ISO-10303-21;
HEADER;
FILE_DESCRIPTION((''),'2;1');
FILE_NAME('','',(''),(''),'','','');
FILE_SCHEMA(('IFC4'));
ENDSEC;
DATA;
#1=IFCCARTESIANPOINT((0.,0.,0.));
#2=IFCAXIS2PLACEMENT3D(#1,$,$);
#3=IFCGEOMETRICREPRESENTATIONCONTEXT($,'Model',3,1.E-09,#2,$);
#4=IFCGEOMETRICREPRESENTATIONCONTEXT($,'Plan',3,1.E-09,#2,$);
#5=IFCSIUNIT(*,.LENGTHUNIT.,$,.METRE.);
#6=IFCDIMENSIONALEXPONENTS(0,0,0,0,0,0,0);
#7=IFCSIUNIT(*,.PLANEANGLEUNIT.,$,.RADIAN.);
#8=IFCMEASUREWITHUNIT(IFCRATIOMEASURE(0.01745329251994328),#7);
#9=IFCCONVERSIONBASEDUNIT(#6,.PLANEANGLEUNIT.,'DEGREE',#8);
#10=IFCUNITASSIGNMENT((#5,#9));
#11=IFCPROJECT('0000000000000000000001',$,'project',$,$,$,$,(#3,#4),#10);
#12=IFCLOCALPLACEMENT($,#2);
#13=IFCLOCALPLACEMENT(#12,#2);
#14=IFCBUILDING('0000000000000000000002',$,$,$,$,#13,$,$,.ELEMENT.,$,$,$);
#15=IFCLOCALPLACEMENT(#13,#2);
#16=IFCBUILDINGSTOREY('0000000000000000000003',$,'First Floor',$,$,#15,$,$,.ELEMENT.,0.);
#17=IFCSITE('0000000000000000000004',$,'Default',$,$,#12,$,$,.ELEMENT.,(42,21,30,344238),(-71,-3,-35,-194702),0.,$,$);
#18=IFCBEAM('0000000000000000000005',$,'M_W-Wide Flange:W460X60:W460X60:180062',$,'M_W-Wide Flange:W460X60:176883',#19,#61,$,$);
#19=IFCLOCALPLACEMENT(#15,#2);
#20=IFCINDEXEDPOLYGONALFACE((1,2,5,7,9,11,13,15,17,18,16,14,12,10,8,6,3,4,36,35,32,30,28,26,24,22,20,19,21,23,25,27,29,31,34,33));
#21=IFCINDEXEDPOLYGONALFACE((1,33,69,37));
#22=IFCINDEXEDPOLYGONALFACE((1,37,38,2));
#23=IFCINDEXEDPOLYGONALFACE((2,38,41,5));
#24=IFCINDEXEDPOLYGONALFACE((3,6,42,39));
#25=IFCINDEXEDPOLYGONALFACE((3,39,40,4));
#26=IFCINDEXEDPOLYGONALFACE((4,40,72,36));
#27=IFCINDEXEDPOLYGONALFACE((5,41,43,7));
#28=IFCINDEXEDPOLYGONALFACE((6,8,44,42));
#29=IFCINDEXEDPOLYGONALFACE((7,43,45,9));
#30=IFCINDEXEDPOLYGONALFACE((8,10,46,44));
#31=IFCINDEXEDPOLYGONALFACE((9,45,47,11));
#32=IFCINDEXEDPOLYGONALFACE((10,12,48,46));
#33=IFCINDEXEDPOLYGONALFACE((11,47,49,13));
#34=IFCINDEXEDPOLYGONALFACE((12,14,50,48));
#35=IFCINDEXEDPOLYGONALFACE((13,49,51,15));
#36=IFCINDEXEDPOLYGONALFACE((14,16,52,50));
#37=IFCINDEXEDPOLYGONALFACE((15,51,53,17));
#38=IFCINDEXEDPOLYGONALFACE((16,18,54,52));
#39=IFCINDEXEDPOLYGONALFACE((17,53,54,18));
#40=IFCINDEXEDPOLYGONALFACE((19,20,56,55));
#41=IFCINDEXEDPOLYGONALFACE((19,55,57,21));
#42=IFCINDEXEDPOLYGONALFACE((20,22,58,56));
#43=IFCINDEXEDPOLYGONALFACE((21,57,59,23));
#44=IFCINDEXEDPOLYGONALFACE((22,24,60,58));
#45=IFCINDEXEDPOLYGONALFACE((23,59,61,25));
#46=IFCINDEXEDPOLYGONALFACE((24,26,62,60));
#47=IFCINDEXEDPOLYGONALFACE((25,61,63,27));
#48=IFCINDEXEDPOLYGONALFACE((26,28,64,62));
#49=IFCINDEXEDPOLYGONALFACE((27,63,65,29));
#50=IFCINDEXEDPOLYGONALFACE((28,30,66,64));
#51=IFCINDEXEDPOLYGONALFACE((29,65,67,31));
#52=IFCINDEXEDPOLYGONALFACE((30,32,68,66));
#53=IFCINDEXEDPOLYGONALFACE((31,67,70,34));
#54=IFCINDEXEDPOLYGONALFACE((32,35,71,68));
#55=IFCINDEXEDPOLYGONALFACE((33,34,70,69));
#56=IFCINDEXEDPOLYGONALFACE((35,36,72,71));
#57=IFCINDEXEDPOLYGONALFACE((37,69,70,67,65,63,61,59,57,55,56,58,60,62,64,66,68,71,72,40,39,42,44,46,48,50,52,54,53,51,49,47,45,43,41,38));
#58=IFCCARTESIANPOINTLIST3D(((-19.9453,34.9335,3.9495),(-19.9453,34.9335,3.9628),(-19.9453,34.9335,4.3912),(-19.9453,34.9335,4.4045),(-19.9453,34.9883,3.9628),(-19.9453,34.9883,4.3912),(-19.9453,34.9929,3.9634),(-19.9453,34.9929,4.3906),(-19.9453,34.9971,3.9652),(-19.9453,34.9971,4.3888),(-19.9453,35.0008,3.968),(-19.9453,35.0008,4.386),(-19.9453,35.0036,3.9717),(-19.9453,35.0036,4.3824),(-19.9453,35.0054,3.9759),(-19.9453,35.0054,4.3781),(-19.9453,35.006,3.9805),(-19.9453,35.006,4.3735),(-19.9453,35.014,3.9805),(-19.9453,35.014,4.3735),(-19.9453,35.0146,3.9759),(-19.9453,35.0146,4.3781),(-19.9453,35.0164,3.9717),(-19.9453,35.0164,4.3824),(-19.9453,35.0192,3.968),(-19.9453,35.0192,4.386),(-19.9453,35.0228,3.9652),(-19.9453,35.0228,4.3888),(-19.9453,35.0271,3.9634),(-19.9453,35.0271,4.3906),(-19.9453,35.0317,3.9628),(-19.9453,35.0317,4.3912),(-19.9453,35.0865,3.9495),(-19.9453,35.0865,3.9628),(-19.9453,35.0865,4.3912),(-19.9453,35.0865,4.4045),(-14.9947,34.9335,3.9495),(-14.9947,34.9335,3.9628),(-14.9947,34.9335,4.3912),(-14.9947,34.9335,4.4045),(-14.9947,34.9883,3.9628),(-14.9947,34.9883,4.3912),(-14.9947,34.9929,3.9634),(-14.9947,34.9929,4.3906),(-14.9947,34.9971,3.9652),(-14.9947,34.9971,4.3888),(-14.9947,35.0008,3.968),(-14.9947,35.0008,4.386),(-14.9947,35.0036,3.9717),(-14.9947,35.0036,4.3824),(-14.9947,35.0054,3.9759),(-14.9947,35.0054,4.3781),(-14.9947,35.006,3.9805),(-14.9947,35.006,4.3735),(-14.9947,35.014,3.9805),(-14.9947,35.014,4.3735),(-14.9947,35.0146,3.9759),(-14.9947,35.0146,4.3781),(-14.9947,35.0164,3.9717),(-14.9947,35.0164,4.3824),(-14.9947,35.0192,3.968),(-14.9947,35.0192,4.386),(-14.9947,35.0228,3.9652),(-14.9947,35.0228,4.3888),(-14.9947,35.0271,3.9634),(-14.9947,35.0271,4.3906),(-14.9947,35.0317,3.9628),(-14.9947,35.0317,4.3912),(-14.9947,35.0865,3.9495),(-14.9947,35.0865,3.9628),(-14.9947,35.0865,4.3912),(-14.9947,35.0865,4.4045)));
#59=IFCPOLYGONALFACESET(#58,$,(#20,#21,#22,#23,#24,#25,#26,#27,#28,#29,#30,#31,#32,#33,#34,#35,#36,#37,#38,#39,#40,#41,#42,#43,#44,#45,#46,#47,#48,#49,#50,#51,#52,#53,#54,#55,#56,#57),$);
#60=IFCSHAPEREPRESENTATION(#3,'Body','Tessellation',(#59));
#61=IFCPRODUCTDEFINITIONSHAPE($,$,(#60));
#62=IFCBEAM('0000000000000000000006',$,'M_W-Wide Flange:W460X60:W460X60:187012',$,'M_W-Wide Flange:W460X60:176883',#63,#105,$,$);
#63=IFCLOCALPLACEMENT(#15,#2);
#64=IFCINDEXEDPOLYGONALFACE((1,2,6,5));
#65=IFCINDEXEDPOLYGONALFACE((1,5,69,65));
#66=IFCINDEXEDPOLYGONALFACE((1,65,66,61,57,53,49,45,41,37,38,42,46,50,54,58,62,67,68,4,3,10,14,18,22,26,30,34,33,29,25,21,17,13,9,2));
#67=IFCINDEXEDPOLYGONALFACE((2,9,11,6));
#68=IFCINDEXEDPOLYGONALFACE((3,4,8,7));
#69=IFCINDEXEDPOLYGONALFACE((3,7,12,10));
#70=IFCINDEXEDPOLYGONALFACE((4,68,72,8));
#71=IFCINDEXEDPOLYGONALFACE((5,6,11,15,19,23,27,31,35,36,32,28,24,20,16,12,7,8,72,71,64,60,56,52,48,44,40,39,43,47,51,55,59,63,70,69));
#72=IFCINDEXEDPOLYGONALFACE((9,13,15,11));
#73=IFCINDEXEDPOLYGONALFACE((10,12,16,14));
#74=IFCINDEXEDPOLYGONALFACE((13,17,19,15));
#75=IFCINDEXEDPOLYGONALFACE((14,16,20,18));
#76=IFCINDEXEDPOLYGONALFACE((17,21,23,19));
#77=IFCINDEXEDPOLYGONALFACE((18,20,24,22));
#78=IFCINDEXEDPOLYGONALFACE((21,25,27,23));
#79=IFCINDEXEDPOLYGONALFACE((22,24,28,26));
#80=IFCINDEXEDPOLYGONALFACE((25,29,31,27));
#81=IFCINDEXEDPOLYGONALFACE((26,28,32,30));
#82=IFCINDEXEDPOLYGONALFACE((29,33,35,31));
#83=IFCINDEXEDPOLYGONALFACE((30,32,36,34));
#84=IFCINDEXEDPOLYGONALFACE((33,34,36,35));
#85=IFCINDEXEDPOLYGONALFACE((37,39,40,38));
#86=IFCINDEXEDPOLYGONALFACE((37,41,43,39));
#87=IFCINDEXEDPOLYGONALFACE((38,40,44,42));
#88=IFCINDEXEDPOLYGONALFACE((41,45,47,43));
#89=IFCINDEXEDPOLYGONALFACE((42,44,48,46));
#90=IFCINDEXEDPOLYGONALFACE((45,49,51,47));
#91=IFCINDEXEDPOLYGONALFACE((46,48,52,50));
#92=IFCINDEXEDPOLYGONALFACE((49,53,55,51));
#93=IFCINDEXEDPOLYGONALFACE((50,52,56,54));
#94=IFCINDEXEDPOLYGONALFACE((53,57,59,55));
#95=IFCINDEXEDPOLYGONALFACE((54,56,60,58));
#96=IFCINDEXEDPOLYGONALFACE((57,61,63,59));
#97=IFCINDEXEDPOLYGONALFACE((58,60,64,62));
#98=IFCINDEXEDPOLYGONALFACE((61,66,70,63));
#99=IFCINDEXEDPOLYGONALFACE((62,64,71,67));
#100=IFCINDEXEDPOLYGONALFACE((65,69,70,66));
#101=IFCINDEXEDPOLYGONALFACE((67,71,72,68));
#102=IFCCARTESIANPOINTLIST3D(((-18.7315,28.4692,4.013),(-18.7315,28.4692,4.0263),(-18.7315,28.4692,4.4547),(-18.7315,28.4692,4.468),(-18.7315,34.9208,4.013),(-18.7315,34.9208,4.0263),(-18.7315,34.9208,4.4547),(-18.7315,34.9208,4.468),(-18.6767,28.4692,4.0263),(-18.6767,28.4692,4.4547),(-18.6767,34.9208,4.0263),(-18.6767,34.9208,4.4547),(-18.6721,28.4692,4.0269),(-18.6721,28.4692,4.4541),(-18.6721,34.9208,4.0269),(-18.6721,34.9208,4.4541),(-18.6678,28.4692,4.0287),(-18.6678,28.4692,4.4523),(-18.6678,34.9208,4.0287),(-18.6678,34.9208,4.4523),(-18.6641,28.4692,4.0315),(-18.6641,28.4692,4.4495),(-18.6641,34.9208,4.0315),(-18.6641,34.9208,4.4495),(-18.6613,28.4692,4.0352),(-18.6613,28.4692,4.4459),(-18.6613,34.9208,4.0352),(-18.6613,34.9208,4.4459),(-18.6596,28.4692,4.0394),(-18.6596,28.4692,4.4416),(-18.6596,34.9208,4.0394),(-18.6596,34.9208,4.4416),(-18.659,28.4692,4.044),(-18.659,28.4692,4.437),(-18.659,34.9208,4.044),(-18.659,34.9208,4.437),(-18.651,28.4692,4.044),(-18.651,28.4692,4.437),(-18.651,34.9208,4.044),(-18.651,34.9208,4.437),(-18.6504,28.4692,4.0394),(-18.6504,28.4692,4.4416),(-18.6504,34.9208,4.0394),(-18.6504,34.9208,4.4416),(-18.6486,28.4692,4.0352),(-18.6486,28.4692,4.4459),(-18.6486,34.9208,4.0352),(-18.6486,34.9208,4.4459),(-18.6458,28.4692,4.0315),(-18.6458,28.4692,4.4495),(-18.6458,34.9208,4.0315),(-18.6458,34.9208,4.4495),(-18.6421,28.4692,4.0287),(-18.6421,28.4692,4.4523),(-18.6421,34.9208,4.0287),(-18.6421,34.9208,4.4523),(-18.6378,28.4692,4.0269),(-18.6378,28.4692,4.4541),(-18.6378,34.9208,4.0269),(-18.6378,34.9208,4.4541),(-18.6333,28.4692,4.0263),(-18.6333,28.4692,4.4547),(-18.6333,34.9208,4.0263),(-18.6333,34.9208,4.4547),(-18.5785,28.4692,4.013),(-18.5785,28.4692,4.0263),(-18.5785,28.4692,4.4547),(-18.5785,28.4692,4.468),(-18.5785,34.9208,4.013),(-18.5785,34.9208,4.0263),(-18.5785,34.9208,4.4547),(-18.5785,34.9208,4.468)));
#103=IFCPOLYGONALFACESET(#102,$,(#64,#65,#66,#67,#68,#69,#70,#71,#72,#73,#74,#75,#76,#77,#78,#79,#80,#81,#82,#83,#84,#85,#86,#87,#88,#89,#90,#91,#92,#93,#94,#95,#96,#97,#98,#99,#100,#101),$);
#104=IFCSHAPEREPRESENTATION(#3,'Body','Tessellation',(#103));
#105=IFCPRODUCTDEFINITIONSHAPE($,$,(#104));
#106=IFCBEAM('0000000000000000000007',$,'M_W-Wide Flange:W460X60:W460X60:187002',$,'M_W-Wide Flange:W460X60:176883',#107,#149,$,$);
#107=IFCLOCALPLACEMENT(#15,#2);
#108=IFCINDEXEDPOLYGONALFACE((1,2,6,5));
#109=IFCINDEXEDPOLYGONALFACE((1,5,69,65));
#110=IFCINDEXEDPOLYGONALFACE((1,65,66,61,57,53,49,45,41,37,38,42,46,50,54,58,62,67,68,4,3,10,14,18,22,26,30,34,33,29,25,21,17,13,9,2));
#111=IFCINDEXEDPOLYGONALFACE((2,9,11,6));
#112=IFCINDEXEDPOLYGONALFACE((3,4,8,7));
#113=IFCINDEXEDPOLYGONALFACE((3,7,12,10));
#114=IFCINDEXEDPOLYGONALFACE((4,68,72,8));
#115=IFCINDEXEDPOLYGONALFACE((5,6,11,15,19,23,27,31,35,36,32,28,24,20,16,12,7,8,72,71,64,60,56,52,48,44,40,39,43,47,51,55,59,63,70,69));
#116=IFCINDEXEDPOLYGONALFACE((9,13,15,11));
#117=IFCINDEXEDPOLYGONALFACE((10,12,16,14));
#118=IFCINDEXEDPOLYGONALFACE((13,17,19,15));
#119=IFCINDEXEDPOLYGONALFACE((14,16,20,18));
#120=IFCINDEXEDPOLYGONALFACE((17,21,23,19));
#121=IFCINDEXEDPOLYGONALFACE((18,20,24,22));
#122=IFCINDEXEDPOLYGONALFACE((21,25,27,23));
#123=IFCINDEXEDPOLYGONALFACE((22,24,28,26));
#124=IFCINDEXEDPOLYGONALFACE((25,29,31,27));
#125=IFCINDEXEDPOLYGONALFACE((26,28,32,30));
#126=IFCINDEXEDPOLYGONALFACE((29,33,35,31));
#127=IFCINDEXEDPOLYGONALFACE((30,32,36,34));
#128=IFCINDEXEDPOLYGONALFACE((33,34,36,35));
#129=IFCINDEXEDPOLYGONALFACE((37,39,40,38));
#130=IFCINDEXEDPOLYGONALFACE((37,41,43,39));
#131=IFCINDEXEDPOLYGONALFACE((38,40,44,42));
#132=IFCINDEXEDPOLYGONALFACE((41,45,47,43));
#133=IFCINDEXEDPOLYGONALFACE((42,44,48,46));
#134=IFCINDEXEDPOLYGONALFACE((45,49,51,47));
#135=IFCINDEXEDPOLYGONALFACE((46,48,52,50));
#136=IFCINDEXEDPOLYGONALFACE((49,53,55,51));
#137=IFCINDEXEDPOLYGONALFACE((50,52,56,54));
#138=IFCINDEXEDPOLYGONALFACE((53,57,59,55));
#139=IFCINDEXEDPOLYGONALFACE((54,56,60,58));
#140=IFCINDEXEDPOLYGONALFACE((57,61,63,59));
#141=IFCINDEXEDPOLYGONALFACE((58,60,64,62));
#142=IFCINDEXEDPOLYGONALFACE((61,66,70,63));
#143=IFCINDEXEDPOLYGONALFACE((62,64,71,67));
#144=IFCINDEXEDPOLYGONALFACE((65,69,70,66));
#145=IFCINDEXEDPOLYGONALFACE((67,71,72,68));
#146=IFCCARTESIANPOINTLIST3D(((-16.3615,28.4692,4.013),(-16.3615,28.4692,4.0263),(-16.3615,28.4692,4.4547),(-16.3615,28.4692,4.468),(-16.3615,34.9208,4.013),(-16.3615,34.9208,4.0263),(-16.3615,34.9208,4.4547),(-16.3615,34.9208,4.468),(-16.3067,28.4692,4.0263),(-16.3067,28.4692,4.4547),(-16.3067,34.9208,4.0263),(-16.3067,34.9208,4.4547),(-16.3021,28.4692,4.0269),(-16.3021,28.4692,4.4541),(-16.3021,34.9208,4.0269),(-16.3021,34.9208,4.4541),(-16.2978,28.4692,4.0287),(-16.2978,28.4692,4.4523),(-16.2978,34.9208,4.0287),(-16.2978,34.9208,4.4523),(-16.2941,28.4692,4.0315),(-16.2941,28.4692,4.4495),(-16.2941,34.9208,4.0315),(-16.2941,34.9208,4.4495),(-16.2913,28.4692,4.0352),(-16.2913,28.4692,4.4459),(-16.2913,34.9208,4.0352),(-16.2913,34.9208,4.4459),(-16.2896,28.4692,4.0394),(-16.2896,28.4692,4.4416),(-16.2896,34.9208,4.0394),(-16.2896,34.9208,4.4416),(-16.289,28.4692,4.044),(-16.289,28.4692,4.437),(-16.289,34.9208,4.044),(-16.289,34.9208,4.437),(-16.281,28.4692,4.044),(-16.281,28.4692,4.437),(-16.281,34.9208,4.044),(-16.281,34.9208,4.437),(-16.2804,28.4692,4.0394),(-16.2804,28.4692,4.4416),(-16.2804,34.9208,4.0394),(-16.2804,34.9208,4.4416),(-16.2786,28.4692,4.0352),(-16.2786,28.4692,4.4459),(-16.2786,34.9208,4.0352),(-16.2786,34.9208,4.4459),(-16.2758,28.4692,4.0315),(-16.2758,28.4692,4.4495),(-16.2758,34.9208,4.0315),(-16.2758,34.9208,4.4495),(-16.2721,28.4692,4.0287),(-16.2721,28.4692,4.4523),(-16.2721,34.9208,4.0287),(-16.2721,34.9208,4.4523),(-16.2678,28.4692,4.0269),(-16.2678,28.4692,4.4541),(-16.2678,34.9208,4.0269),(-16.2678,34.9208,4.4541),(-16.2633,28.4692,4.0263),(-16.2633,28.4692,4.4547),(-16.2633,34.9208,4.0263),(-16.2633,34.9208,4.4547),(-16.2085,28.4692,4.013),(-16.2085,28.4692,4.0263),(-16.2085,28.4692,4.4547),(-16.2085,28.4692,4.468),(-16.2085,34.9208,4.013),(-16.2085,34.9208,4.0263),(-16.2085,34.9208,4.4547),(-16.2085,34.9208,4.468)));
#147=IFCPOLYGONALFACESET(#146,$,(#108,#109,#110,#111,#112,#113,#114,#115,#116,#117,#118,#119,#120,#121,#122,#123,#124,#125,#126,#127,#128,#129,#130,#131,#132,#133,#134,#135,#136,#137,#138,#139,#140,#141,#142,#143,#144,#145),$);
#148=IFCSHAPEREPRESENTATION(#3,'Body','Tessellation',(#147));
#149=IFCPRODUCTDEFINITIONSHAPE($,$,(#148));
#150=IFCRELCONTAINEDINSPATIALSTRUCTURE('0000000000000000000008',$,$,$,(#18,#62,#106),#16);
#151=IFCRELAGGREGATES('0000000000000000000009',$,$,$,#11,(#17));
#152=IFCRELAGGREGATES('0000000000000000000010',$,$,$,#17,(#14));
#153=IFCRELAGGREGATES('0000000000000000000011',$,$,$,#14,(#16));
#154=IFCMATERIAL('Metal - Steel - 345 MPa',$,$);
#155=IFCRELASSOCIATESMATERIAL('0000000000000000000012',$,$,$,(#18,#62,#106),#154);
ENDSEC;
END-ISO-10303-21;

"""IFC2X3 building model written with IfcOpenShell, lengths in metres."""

from ifc_helpers import new_model, entity, si_unit, converted_unit, frame, frame_2d, origin, place, context, project, spatial, polyline, circle_curve, parameter, trimmed, segment, composite_curve, outline, extrude, material, element, save


model = new_model("IFC2X3")

# Units and contexts
model_context = context("Model", 3, precision=1e-09, world=origin())
plan_context = context("Plan", 3, precision=1e-09, world=origin())
ifc_project = project(units=[si_unit("LENGTHUNIT", "METRE"), converted_unit("PLANEANGLEUNIT", "DEGREE", entity("IfcRatioMeasure", 0.01745329251994328), si_unit("PLANEANGLEUNIT", "RADIAN"), dimensions=[0, 0, 0, 0, 0, 0, 0])], contexts=[model_context, plan_context])

# Site, building, storey
site_placement = place(None, origin())
site = spatial("IfcSite", under=ifc_project, at=site_placement, Name="Default", CompositionType="ELEMENT", RefLatitude=(42, 21, 30, 344238), RefLongitude=(-71, -3, -35, -194702), RefElevation=0.0)
building_placement = place(site_placement, origin())
building = spatial("IfcBuilding", under=site, at=building_placement, CompositionType="ELEMENT")
storey_placement = place(building_placement, origin())
storey = spatial("IfcBuildingStorey", under=building, at=storey_placement, Name="First Floor", CompositionType="ELEMENT", Elevation=0.0)

# Shared definitions
ifc_material = material(Name="Metal - Steel - 345 MPa")

# Beams
beam_1_placement = place(storey_placement, frame((-14.8773, 35.01, 4.4045), z_axis=(0.0, 0.0, 1.0), x_axis=(0.0, 1.0, 0.0)))
element("IfcBeam", 1, at=beam_1_placement, inside=storey, material=ifc_material, Name="M_W-Wide Flange:W460X60:W460X60:180062", ObjectType="M_W-Wide Flange:W460X60:176883", context=model_context, shape_type="SweptSolid", body=[
    extrude(outline(composite_curve([segment(polyline([(0.2142, -0.0765), (0.2275, -0.0765)]), True, "CONTINUOUS"), segment(polyline([(0.2275, -0.0765), (0.2275, 0.0765)]), True, "CONTINUOUS"), segment(polyline([(0.2275, 0.0765), (0.2142, 0.0765)]), True, "CONTINUOUS"), segment(polyline([(0.2142, 0.0765), (0.2142, 0.0217)]), True, "CONTINUOUS"), segment(trimmed(circle_curve(frame_2d((0.1965, 0.0217), x_axis=(1.0, 0.0)), 0.0177), [parameter(270.0)], [parameter(360.0)], True, "PARAMETER"), False, "CONTINUOUS"), segment(polyline([(0.1965, 0.004), (-0.1965, 0.004)]), True, "CONTINUOUS"), segment(trimmed(circle_curve(frame_2d((-0.1965, 0.0217), x_axis=(0.0, -1.0)), 0.0177), [parameter(270.0)], [parameter(360.0)], True, "PARAMETER"), False, "CONTINUOUS"), segment(polyline([(-0.2142, 0.0217), (-0.2142, 0.0765)]), True, "CONTINUOUS"), segment(polyline([(-0.2142, 0.0765), (-0.2275, 0.0765)]), True, "CONTINUOUS"), segment(polyline([(-0.2275, 0.0765), (-0.2275, -0.0765)]), True, "CONTINUOUS"), segment(polyline([(-0.2275, -0.0765), (-0.2142, -0.0765)]), True, "CONTINUOUS"), segment(polyline([(-0.2142, -0.0765), (-0.2142, -0.0217)]), True, "CONTINUOUS"), segment(trimmed(circle_curve(frame_2d((-0.1965, -0.0217), x_axis=(-1.0, 0.0)), 0.0177), [parameter(270.0)], [parameter(360.0)], True, "PARAMETER"), False, "CONTINUOUS"), segment(polyline([(-0.1965, -0.004), (0.1965, -0.004)]), True, "CONTINUOUS"), segment(trimmed(circle_curve(frame_2d((0.1965, -0.0217), x_axis=(0.0, 1.0)), 0.0177), [parameter(270.0)], [parameter(0.0)], True, "PARAMETER"), False, "CONTINUOUS"), segment(polyline([(0.2142, -0.0217), (0.2142, -0.0765)]), True, "CONTINUOUS")], self_intersect=False)), frame((0.0, 5.068, -0.2275), z_axis=(0.0, -1.0, 0.0), x_axis=(0.0, 0.0, -1.0)), (0.0, 0.0, 1.0), 4.9506),
])
beam_2_placement = place(storey_placement, frame((-18.655, 28.528, 4.468)))
element("IfcBeam", 2, at=beam_2_placement, inside=storey, material=ifc_material, Name="M_W-Wide Flange:W460X60:W460X60:187012", ObjectType="M_W-Wide Flange:W460X60:176883", context=model_context, shape_type="SweptSolid", body=[
    extrude(outline(composite_curve([segment(polyline([(-0.0765, -0.2142), (-0.0765, -0.2275)]), True, "CONTINUOUS"), segment(polyline([(-0.0765, -0.2275), (0.0765, -0.2275)]), True, "CONTINUOUS"), segment(polyline([(0.0765, -0.2275), (0.0765, -0.2142)]), True, "CONTINUOUS"), segment(polyline([(0.0765, -0.2142), (0.0217, -0.2142)]), True, "CONTINUOUS"), segment(trimmed(circle_curve(frame_2d((0.0217, -0.1965), x_axis=(1.0, 0.0)), 0.0177), [parameter(180.0)], [parameter(270.0)], True, "PARAMETER"), False, "CONTINUOUS"), segment(polyline([(0.004, -0.1965), (0.004, 0.1965)]), True, "CONTINUOUS"), segment(trimmed(circle_curve(frame_2d((0.0217, 0.1965), x_axis=(1.0, 0.0)), 0.0177), [parameter(90.0)], [parameter(180.0)], True, "PARAMETER"), False, "CONTINUOUS"), segment(polyline([(0.0217, 0.2142), (0.0765, 0.2142)]), True, "CONTINUOUS"), segment(polyline([(0.0765, 0.2142), (0.0765, 0.2275)]), True, "CONTINUOUS"), segment(polyline([(0.0765, 0.2275), (-0.0765, 0.2275)]), True, "CONTINUOUS"), segment(polyline([(-0.0765, 0.2275), (-0.0765, 0.2142)]), True, "CONTINUOUS"), segment(polyline([(-0.0765, 0.2142), (-0.0217, 0.2142)]), True, "CONTINUOUS"), segment(trimmed(circle_curve(frame_2d((-0.0217, 0.1965), x_axis=(1.0, 0.0)), 0.0177), [parameter(360.0)], [parameter(90.0)], True, "PARAMETER"), False, "CONTINUOUS"), segment(polyline([(-0.004, 0.1965), (-0.004, -0.1965)]), True, "CONTINUOUS"), segment(trimmed(circle_curve(frame_2d((-0.0217, -0.1965), x_axis=(1.0, 0.0)), 0.0177), [parameter(270.0)], [parameter(0.0)], True, "PARAMETER"), False, "CONTINUOUS"), segment(polyline([(-0.0217, -0.2142), (-0.0765, -0.2142)]), True, "CONTINUOUS")], self_intersect=False)), frame((0.0, -0.0588, -0.2275), z_axis=(0.0, -1.0, 0.0), x_axis=(1.0, 0.0, 0.0)), (0.0, 0.0, -1.0), 6.4516),
])
beam_3_placement = place(storey_placement, frame((-16.285, 34.8621, 4.468), z_axis=(0.0, 0.0, 1.0), x_axis=(-1.0, 0.0, 0.0)))
element("IfcBeam", 3, at=beam_3_placement, inside=storey, material=ifc_material, Name="M_W-Wide Flange:W460X60:W460X60:187002", ObjectType="M_W-Wide Flange:W460X60:176883", context=model_context, shape_type="SweptSolid", body=[
    extrude(outline(composite_curve([segment(polyline([(0.2142, -0.0765), (0.2275, -0.0765)]), True, "CONTINUOUS"), segment(polyline([(0.2275, -0.0765), (0.2275, 0.0765)]), True, "CONTINUOUS"), segment(polyline([(0.2275, 0.0765), (0.2142, 0.0765)]), True, "CONTINUOUS"), segment(polyline([(0.2142, 0.0765), (0.2142, 0.0217)]), True, "CONTINUOUS"), segment(trimmed(circle_curve(frame_2d((0.1965, 0.0217), x_axis=(0.0, 1.0)), 0.0177), [parameter(180.0)], [parameter(270.0)], True, "PARAMETER"), False, "CONTINUOUS"), segment(polyline([(0.1965, 0.004), (-0.1965, 0.004)]), True, "CONTINUOUS"), segment(trimmed(circle_curve(frame_2d((-0.1965, 0.0217), x_axis=(0.0, 1.0)), 0.0177), [parameter(90.0)], [parameter(180.0)], True, "PARAMETER"), False, "CONTINUOUS"), segment(polyline([(-0.2142, 0.0217), (-0.2142, 0.0765)]), True, "CONTINUOUS"), segment(polyline([(-0.2142, 0.0765), (-0.2275, 0.0765)]), True, "CONTINUOUS"), segment(polyline([(-0.2275, 0.0765), (-0.2275, -0.0765)]), True, "CONTINUOUS"), segment(polyline([(-0.2275, -0.0765), (-0.2142, -0.0765)]), True, "CONTINUOUS"), segment(polyline([(-0.2142, -0.0765), (-0.2142, -0.0217)]), True, "CONTINUOUS"), segment(trimmed(circle_curve(frame_2d((-0.1965, -0.0217), x_axis=(0.0, 1.0)), 0.0177), [parameter(360.0)], [parameter(90.0)], True, "PARAMETER"), False, "CONTINUOUS"), segment(polyline([(-0.1965, -0.004), (0.1965, -0.004)]), True, "CONTINUOUS"), segment(trimmed(circle_curve(frame_2d((0.1965, -0.0217), x_axis=(0.0, 1.0)), 0.0177), [parameter(270.0)], [parameter(0.0)], True, "PARAMETER"), False, "CONTINUOUS"), segment(polyline([(0.2142, -0.0217), (0.2142, -0.0765)]), True, "CONTINUOUS")], self_intersect=False)), frame((0.0, 6.3929, -0.2275), z_axis=(0.0, -1.0, 0.0), x_axis=(0.0, 0.0, -1.0)), (0.0, 0.0, 1.0), 6.4516),
])

save(model, "model.ifc")
